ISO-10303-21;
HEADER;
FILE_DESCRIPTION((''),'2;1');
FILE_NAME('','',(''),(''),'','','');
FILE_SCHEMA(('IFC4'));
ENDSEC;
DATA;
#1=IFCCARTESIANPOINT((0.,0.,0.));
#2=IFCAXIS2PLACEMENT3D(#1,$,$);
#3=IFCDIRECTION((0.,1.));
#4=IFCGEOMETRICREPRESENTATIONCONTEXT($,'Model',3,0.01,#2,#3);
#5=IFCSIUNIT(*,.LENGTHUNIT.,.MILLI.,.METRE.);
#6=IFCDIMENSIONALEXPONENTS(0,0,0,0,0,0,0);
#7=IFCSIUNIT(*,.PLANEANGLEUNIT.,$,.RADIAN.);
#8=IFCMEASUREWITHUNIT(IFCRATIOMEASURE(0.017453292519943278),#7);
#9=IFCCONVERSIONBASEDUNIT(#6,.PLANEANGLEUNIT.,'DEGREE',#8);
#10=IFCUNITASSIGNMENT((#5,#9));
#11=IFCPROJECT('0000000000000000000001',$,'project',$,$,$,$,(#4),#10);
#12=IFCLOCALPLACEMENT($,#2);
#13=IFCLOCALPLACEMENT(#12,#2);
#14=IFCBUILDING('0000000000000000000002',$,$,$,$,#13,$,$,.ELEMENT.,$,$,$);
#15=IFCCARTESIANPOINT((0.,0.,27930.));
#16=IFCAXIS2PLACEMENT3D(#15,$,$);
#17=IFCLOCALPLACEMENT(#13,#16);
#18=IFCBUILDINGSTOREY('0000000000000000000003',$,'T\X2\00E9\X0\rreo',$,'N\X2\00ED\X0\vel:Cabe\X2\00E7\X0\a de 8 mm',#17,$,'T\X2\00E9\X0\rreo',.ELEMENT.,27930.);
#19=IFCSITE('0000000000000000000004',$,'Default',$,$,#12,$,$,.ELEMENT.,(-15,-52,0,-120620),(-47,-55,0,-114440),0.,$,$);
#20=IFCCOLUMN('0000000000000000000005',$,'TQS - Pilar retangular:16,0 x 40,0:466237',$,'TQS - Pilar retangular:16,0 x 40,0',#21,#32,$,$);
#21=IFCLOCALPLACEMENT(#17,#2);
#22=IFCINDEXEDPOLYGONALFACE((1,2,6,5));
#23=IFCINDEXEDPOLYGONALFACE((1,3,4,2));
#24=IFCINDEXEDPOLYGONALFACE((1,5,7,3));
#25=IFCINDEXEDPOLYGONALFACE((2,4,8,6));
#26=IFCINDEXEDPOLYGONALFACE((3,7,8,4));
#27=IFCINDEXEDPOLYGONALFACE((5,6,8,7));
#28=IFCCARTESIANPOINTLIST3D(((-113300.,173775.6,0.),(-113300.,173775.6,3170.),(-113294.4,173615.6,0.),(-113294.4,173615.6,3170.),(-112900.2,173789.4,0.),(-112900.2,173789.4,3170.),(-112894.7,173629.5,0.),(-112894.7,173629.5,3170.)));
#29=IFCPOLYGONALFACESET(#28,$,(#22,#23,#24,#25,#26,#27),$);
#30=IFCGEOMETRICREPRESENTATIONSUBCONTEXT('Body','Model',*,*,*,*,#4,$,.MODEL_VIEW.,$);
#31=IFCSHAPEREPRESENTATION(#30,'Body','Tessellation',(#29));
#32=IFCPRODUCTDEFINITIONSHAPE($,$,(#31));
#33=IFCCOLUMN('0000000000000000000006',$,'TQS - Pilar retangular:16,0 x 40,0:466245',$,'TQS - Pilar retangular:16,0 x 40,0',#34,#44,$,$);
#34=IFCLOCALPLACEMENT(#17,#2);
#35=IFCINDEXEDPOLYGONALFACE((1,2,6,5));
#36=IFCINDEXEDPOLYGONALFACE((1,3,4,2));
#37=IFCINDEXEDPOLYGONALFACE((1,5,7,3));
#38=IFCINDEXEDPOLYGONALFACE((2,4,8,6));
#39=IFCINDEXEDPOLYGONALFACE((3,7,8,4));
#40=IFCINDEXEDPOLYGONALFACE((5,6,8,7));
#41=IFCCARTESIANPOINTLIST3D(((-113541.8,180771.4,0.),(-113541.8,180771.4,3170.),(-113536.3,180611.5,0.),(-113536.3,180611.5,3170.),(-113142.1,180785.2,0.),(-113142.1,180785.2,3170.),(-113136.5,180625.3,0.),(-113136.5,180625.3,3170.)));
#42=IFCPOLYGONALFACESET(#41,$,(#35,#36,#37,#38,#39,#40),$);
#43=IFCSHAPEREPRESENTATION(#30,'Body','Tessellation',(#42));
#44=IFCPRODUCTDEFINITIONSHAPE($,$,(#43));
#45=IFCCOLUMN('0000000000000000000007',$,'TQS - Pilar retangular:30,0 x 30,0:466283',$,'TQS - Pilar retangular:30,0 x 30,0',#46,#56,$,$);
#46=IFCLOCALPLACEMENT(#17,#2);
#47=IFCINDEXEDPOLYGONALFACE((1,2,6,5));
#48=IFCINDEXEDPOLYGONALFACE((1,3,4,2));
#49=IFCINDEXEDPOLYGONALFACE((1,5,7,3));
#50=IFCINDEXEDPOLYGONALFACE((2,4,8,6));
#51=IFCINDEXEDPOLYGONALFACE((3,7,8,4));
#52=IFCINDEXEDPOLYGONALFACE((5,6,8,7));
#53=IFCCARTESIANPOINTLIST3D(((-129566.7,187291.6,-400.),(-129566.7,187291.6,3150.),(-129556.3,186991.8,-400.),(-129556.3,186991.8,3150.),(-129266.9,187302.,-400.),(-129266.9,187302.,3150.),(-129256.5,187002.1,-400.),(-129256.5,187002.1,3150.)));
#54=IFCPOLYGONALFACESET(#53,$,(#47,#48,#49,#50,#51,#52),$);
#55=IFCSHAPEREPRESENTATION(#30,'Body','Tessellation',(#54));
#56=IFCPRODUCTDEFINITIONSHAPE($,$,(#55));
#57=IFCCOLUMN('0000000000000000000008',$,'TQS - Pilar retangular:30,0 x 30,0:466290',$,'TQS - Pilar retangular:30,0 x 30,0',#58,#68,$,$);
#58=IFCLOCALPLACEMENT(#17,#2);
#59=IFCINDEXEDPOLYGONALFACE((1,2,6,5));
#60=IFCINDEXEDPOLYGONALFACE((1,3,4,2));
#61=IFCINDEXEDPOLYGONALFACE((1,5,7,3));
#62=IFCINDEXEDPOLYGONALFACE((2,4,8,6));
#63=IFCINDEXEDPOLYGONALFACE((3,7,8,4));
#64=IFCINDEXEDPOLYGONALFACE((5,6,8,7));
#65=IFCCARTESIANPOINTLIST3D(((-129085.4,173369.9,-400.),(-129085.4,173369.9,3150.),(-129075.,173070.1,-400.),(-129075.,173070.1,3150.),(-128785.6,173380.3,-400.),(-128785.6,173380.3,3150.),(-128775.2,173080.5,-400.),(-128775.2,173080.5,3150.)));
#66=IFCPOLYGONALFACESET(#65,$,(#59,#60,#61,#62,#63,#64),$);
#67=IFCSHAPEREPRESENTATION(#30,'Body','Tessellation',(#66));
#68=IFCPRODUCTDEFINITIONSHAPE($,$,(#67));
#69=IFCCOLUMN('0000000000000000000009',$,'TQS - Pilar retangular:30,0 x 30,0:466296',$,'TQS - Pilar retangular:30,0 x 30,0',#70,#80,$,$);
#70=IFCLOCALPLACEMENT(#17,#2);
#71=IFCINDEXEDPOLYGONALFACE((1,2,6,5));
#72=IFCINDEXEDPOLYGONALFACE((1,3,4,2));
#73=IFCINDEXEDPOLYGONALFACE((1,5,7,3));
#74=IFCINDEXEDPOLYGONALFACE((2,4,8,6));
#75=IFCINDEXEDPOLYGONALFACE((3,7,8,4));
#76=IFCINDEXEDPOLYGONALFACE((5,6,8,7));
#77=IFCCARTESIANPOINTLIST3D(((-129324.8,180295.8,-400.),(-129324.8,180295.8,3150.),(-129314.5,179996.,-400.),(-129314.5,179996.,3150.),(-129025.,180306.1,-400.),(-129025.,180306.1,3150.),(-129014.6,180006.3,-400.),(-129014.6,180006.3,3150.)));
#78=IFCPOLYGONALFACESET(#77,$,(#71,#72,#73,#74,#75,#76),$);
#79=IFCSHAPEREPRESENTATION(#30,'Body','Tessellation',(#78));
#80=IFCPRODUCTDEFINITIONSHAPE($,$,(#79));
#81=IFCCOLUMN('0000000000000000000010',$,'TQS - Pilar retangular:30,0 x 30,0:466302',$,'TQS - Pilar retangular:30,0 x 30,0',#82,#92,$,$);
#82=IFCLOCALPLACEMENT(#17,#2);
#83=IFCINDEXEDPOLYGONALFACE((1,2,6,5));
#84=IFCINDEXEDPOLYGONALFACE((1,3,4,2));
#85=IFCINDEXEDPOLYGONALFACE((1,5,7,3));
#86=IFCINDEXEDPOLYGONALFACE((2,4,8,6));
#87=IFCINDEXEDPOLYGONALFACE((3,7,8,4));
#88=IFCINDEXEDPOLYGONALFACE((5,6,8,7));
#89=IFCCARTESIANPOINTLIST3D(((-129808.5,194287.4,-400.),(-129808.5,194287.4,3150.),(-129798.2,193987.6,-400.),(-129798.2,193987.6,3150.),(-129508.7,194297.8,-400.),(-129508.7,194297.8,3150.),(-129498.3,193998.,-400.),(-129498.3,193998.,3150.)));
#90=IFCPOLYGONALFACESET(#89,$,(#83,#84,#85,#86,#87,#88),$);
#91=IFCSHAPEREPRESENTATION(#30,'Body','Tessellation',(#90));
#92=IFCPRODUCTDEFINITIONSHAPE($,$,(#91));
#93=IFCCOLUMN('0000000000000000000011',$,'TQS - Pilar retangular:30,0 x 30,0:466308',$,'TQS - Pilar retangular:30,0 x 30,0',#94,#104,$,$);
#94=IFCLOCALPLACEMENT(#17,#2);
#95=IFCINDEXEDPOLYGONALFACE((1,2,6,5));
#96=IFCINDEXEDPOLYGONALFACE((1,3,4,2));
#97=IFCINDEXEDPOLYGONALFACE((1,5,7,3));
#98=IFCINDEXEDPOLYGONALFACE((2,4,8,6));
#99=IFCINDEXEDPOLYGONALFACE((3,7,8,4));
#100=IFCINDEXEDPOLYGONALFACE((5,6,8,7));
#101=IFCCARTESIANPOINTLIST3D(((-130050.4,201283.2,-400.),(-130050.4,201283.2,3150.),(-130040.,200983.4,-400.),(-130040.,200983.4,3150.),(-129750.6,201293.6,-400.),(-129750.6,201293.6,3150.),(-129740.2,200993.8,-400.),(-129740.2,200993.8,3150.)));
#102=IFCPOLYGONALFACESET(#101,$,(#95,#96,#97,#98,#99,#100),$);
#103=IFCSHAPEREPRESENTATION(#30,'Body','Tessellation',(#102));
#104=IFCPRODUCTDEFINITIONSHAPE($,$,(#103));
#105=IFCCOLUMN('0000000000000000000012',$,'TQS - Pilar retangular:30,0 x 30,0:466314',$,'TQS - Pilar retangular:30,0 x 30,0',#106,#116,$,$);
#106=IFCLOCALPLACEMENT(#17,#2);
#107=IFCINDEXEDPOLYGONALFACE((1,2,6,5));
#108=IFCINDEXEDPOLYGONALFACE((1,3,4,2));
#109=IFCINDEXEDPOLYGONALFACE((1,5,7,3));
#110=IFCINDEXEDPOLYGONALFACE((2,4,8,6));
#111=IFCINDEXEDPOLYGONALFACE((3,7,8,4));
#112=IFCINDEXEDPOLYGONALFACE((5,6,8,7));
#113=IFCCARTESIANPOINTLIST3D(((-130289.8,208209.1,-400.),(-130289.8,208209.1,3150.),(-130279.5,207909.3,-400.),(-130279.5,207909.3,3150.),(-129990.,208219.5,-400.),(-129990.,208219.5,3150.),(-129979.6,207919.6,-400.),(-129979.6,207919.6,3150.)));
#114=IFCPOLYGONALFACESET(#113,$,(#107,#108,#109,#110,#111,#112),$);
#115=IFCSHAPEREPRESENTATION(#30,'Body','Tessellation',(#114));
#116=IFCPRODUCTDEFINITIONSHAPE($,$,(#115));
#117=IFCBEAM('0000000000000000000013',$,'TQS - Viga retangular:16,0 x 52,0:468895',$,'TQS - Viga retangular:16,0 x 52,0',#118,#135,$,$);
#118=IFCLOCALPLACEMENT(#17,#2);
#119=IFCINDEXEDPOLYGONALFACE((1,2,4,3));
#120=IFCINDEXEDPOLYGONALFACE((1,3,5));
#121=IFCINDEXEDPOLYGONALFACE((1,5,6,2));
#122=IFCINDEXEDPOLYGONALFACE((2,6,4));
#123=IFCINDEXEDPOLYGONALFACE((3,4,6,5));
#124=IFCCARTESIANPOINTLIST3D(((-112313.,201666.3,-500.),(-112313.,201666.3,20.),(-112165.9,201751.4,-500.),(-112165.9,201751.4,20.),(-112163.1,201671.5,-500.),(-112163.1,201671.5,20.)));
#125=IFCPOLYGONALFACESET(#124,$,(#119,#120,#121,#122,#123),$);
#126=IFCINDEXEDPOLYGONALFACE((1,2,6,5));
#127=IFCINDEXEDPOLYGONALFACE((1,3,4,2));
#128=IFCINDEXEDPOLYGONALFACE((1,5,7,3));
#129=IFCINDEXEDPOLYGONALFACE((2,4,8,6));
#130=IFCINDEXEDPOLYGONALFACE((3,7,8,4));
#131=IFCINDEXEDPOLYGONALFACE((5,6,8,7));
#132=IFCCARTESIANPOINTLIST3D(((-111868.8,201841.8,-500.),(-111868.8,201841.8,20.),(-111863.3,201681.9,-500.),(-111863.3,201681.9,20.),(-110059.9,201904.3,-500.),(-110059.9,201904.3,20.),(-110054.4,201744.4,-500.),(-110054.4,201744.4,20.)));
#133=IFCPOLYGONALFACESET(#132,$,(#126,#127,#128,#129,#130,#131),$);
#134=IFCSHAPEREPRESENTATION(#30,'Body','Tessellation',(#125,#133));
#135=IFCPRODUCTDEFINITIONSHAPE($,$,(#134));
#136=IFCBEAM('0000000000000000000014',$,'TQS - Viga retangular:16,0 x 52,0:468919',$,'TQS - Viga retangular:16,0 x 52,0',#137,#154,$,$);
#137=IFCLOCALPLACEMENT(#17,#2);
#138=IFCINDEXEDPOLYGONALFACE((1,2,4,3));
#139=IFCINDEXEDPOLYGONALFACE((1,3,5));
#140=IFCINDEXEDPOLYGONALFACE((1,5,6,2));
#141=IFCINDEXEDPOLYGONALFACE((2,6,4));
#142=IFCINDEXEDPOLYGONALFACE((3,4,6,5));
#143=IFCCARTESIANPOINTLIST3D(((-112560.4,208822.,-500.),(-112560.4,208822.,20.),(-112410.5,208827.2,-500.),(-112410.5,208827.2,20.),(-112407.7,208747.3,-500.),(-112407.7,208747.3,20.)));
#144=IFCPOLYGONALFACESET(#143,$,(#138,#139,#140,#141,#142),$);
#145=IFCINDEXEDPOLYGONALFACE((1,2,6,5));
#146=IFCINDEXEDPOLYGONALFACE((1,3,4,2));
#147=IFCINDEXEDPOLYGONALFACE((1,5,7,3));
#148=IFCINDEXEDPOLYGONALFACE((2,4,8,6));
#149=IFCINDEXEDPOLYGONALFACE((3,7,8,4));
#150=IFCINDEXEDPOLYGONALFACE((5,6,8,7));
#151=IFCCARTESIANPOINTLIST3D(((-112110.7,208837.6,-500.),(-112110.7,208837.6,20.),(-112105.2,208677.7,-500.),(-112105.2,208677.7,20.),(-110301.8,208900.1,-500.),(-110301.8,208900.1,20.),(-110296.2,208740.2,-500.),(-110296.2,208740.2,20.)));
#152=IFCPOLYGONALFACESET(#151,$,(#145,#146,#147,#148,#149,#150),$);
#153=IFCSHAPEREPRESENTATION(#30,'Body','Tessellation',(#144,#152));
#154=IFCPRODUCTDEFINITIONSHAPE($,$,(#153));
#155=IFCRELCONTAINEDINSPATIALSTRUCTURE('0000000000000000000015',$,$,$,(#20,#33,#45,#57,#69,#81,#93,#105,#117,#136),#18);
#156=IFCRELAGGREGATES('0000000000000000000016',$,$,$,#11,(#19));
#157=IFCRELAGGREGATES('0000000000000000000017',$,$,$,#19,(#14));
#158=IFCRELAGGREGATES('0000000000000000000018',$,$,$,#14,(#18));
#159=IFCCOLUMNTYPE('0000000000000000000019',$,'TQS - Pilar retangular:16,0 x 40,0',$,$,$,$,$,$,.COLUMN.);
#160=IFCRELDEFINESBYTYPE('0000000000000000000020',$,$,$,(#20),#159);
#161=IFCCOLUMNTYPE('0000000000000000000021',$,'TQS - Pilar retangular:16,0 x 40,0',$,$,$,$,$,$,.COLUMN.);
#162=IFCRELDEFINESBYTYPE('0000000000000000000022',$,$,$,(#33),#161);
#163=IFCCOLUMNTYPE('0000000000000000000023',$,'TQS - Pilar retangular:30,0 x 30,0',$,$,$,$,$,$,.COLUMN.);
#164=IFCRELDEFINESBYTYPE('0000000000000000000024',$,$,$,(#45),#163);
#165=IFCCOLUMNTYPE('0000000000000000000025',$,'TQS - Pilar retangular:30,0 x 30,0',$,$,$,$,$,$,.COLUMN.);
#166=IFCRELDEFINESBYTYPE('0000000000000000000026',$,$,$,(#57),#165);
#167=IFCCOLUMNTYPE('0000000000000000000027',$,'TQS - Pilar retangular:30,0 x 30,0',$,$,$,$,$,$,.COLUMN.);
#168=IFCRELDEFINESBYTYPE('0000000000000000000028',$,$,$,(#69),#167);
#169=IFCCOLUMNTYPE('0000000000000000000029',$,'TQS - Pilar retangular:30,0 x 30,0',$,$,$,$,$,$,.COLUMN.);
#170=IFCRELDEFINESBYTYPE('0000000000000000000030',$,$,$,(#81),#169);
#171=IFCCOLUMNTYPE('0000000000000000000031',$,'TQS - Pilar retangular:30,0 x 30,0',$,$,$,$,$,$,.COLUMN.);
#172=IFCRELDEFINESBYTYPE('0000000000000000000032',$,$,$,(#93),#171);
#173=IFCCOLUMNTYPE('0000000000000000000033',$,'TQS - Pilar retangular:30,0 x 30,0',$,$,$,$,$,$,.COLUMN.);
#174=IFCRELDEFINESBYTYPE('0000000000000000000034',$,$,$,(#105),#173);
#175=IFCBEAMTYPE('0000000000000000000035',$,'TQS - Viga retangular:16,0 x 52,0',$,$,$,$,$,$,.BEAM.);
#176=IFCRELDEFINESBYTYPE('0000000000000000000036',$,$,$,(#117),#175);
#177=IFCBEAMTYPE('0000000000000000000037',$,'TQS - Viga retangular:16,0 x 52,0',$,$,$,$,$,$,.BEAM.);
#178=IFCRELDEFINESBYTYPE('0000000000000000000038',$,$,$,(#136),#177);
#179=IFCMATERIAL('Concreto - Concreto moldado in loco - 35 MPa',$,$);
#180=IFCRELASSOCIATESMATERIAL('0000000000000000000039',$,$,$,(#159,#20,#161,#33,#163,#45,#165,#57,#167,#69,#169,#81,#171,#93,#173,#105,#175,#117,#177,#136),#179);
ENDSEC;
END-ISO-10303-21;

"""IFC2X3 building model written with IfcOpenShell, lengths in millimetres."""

from ifc_helpers import new_model, entity, si_unit, converted_unit, direction, frame, frame_2d, origin, origin_2d_with_axis, place, context, subcontext, project, spatial, rectangle, extrude, clip, halfspace, source, transform, mapped, material, type_object, type_shapes, element, save


model = new_model("IFC2X3")

# Units and contexts
model_context = context("Model", 3, precision=0.01, world=origin(), true_north=direction((0.0, 1.0)))
body_context = subcontext(model_context, "Body", "Model", "MODEL_VIEW")
ifc_project = project(units=[si_unit("LENGTHUNIT", "METRE", prefix="MILLI"), converted_unit("PLANEANGLEUNIT", "DEGREE", entity("IfcRatioMeasure", 0.017453292519943278), si_unit("PLANEANGLEUNIT", "RADIAN"), dimensions=[0, 0, 0, 0, 0, 0, 0])], contexts=[model_context])

# Site, building, storey
site_placement = place(None, origin())
site = spatial("IfcSite", under=ifc_project, at=site_placement, Name="Default", CompositionType="ELEMENT", RefLatitude=(-15, -52, 0, -120620), RefLongitude=(-47, -55, 0, -114440), RefElevation=0.0)
building_placement = place(site_placement, origin())
building = spatial("IfcBuilding", under=site, at=building_placement, CompositionType="ELEMENT")
storey_placement = place(building_placement, frame((0.0, 0.0, 27930.0)))
storey = spatial("IfcBuildingStorey", under=building, at=storey_placement, Name="Térreo", ObjectType="Nível:Cabeça de 8 mm", LongName="Térreo", CompositionType="ELEMENT", Elevation=27930.0)

# Columns
ifc_material = material(Name="Concreto - Concreto moldado in loco - 35 MPa")
column_type_1 = type_object("IfcColumnType", Name="TQS - Pilar retangular:16,0 x 40,0", PredefinedType="COLUMN", material=ifc_material)
shared_shape_1 = source(origin(), body_context, "Body", "SweptSolid", [
    extrude(rectangle(XDim=400.0, YDim=160.0, at=origin_2d_with_axis()), frame((-113097.3, 173702.5, 27930.0), z_axis=(0.0, 0.0, 1.0), x_axis=(-0.999403, -0.034551, 0.0)), (0.0, 0.0, 1.0), 3170.0),
])
type_shapes(column_type_1, [shared_shape_1])
column_1_placement = place(storey_placement, frame((0.0, 0.0, -27930.0)))
element("IfcColumn", 1, at=column_1_placement, inside=storey, type_object=column_type_1, material=ifc_material, Name="TQS - Pilar retangular:16,0 x 40,0:466237", ObjectType="TQS - Pilar retangular:16,0 x 40,0", context=body_context, shape_type="MappedRepresentation", body=[
    mapped(shared_shape_1, transform((0.0, 0.0, 0.0), scale=1.0)),
])
column_type_2 = type_object("IfcColumnType", Name="TQS - Pilar retangular:16,0 x 40,0", PredefinedType="COLUMN", material=ifc_material)
shared_shape_2 = source(origin(), body_context, "Body", "SweptSolid", [
    extrude(rectangle(XDim=400.0, YDim=160.0, at=origin_2d_with_axis()), frame((-113339.2, 180698.3, 27930.0), z_axis=(0.0, 0.0, 1.0), x_axis=(-0.999403, -0.034551, 0.0)), (0.0, 0.0, 1.0), 3170.0),
])
type_shapes(column_type_2, [shared_shape_2])
column_2_placement = place(storey_placement, frame((0.0, 0.0, -27930.0)))
element("IfcColumn", 2, at=column_2_placement, inside=storey, type_object=column_type_2, material=ifc_material, Name="TQS - Pilar retangular:16,0 x 40,0:466245", ObjectType="TQS - Pilar retangular:16,0 x 40,0", context=body_context, shape_type="MappedRepresentation", body=[
    mapped(shared_shape_2, transform((0.0, 0.0, 0.0), scale=1.0)),
])
column_type_3 = type_object("IfcColumnType", Name="TQS - Pilar retangular:30,0 x 30,0", PredefinedType="COLUMN", material=ifc_material)
shared_shape_3 = source(origin(), body_context, "Body", "SweptSolid", [
    extrude(rectangle(XDim=300.0, YDim=300.0, at=origin_2d_with_axis()), frame((-129411.6, 187146.9, 27530.0), z_axis=(0.0, 0.0, 1.0), x_axis=(-0.999403, -0.034551, 0.0)), (0.0, 0.0, 1.0), 3550.0),
])
type_shapes(column_type_3, [shared_shape_3])
column_3_placement = place(storey_placement, frame((0.0, 0.0, -27930.0)))
element("IfcColumn", 3, at=column_3_placement, inside=storey, type_object=column_type_3, material=ifc_material, Name="TQS - Pilar retangular:30,0 x 30,0:466283", ObjectType="TQS - Pilar retangular:30,0 x 30,0", context=body_context, shape_type="MappedRepresentation", body=[
    mapped(shared_shape_3, transform((0.0, 0.0, 0.0), scale=1.0)),
])
column_type_4 = type_object("IfcColumnType", Name="TQS - Pilar retangular:30,0 x 30,0", PredefinedType="COLUMN", material=ifc_material)
shared_shape_4 = source(origin(), body_context, "Body", "SweptSolid", [
    extrude(rectangle(XDim=300.0, YDim=300.0, at=origin_2d_with_axis()), frame((-128930.3, 173225.2, 27530.0), z_axis=(0.0, 0.0, 1.0), x_axis=(-0.999403, -0.034551, 0.0)), (0.0, 0.0, 1.0), 3550.0),
])
type_shapes(column_type_4, [shared_shape_4])
column_4_placement = place(storey_placement, frame((0.0, 0.0, -27930.0)))
element("IfcColumn", 4, at=column_4_placement, inside=storey, type_object=column_type_4, material=ifc_material, Name="TQS - Pilar retangular:30,0 x 30,0:466290", ObjectType="TQS - Pilar retangular:30,0 x 30,0", context=body_context, shape_type="MappedRepresentation", body=[
    mapped(shared_shape_4, transform((0.0, 0.0, 0.0), scale=1.0)),
])
column_type_5 = type_object("IfcColumnType", Name="TQS - Pilar retangular:30,0 x 30,0", PredefinedType="COLUMN", material=ifc_material)
shared_shape_5 = source(origin(), body_context, "Body", "SweptSolid", [
    extrude(rectangle(XDim=300.0, YDim=300.0, at=origin_2d_with_axis()), frame((-129169.7, 180151.1, 27530.0), z_axis=(0.0, 0.0, 1.0), x_axis=(-0.999403, -0.034551, 0.0)), (0.0, 0.0, 1.0), 3550.0),
])
type_shapes(column_type_5, [shared_shape_5])
column_5_placement = place(storey_placement, frame((0.0, 0.0, -27930.0)))
element("IfcColumn", 5, at=column_5_placement, inside=storey, type_object=column_type_5, material=ifc_material, Name="TQS - Pilar retangular:30,0 x 30,0:466296", ObjectType="TQS - Pilar retangular:30,0 x 30,0", context=body_context, shape_type="MappedRepresentation", body=[
    mapped(shared_shape_5, transform((0.0, 0.0, 0.0), scale=1.0)),
])
column_type_6 = type_object("IfcColumnType", Name="TQS - Pilar retangular:30,0 x 30,0", PredefinedType="COLUMN", material=ifc_material)
shared_shape_6 = source(origin(), body_context, "Body", "SweptSolid", [
    extrude(rectangle(XDim=300.0, YDim=300.0, at=origin_2d_with_axis()), frame((-129653.4, 194142.7, 27530.0), z_axis=(0.0, 0.0, 1.0), x_axis=(-0.999403, -0.034551, 0.0)), (0.0, 0.0, 1.0), 3550.0),
])
type_shapes(column_type_6, [shared_shape_6])
column_6_placement = place(storey_placement, frame((0.0, 0.0, -27930.0)))
element("IfcColumn", 6, at=column_6_placement, inside=storey, type_object=column_type_6, material=ifc_material, Name="TQS - Pilar retangular:30,0 x 30,0:466302", ObjectType="TQS - Pilar retangular:30,0 x 30,0", context=body_context, shape_type="MappedRepresentation", body=[
    mapped(shared_shape_6, transform((0.0, 0.0, 0.0), scale=1.0)),
])
column_type_7 = type_object("IfcColumnType", Name="TQS - Pilar retangular:30,0 x 30,0", PredefinedType="COLUMN", material=ifc_material)
shared_shape_7 = source(origin(), body_context, "Body", "SweptSolid", [
    extrude(rectangle(XDim=300.0, YDim=300.0, at=origin_2d_with_axis()), frame((-129895.3, 201138.5, 27530.0), z_axis=(0.0, 0.0, 1.0), x_axis=(-0.999403, -0.034551, 0.0)), (0.0, 0.0, 1.0), 3550.0),
])
type_shapes(column_type_7, [shared_shape_7])
column_7_placement = place(storey_placement, frame((0.0, 0.0, -27930.0)))
element("IfcColumn", 7, at=column_7_placement, inside=storey, type_object=column_type_7, material=ifc_material, Name="TQS - Pilar retangular:30,0 x 30,0:466308", ObjectType="TQS - Pilar retangular:30,0 x 30,0", context=body_context, shape_type="MappedRepresentation", body=[
    mapped(shared_shape_7, transform((0.0, 0.0, 0.0), scale=1.0)),
])
column_type_8 = type_object("IfcColumnType", Name="TQS - Pilar retangular:30,0 x 30,0", PredefinedType="COLUMN", material=ifc_material)
shared_shape_8 = source(origin(), body_context, "Body", "SweptSolid", [
    extrude(rectangle(XDim=300.0, YDim=300.0, at=origin_2d_with_axis()), frame((-130134.7, 208064.4, 27530.0), z_axis=(0.0, 0.0, 1.0), x_axis=(-0.999403, -0.034551, 0.0)), (0.0, 0.0, 1.0), 3550.0),
])
type_shapes(column_type_8, [shared_shape_8])
column_8_placement = place(storey_placement, frame((0.0, 0.0, -27930.0)))
element("IfcColumn", 8, at=column_8_placement, inside=storey, type_object=column_type_8, material=ifc_material, Name="TQS - Pilar retangular:30,0 x 30,0:466314", ObjectType="TQS - Pilar retangular:30,0 x 30,0", context=body_context, shape_type="MappedRepresentation", body=[
    mapped(shared_shape_8, transform((0.0, 0.0, 0.0), scale=1.0)),
])

# Beams
beam_type_1 = type_object("IfcBeamType", Name="TQS - Viga retangular:16,0 x 52,0", PredefinedType="BEAM", material=ifc_material)
shared_shape_9 = source(origin(), body_context, "Body", "SweptSolid", [
    clip(extrude(rectangle(XDim=520.0, YDim=80.0, at=frame_2d((0.0, 0.0), x_axis=(0.0, 1.0))), frame((-112164.5, 201711.5, 27690.0), z_axis=(-0.999403, -0.034551, 0.0), x_axis=(0.034551, -0.999403, 0.0)), (0.0, 0.0, 1.0), 150.0), halfspace(frame((-112018.7, 201836.6, 27950.0), z_axis=(-0.500793, 0.865567, 0.0), x_axis=(0.865567, 0.500793, 0.0)), False)),
    extrude(rectangle(XDim=520.0, YDim=160.0, at=frame_2d((0.0, 0.0), x_axis=(1.0, 0.0))), frame((-110057.1, 201824.3, 27690.0), z_axis=(-0.999403, -0.034551, 0.0), x_axis=(0.0, 0.0, -1.0)), (0.0, 0.0, 1.0), 1810.0),
])
type_shapes(beam_type_1, [shared_shape_9])
beam_1_placement = place(storey_placement, frame((0.0, 0.0, -27930.0)))
element("IfcBeam", 9, at=beam_1_placement, inside=storey, type_object=beam_type_1, material=ifc_material, Name="TQS - Viga retangular:16,0 x 52,0:468895", ObjectType="TQS - Viga retangular:16,0 x 52,0", context=body_context, shape_type="MappedRepresentation", body=[
    mapped(shared_shape_9, transform((0.0, 0.0, 0.0), scale=1.0)),
])
beam_type_2 = type_object("IfcBeamType", Name="TQS - Viga retangular:16,0 x 52,0", PredefinedType="BEAM", material=ifc_material)
shared_shape_10 = source(origin(), body_context, "Body", "SweptSolid", [
    clip(extrude(rectangle(XDim=520.0, YDim=80.0, at=frame_2d((0.0, 0.0), x_axis=(1.0, 0.0))), frame((-112409.1, 208787.2, 27690.0), z_axis=(-0.999403, -0.034551, 0.0), x_axis=(0.0, 0.0, -1.0)), (0.0, 0.0, 1.0), 150.0), halfspace(frame((-112255.1, 208672.5, 27950.0), z_axis=(-0.439821, -0.898085, 0.0), x_axis=(0.898085, -0.439821, 0.0)), False)),
    extrude(rectangle(XDim=520.0, YDim=160.0, at=frame_2d((0.0, 0.0), x_axis=(1.0, 0.0))), frame((-110299.0, 208820.2, 27690.0), z_axis=(-0.999403, -0.034551, 0.0), x_axis=(0.0, 0.0, -1.0)), (0.0, 0.0, 1.0), 1810.0),
])
type_shapes(beam_type_2, [shared_shape_10])
beam_2_placement = place(storey_placement, frame((0.0, 0.0, -27930.0)))
element("IfcBeam", 10, at=beam_2_placement, inside=storey, type_object=beam_type_2, material=ifc_material, Name="TQS - Viga retangular:16,0 x 52,0:468919", ObjectType="TQS - Viga retangular:16,0 x 52,0", context=body_context, shape_type="MappedRepresentation", body=[
    mapped(shared_shape_10, transform((0.0, 0.0, 0.0), scale=1.0)),
])

save(model, "model.ifc")
